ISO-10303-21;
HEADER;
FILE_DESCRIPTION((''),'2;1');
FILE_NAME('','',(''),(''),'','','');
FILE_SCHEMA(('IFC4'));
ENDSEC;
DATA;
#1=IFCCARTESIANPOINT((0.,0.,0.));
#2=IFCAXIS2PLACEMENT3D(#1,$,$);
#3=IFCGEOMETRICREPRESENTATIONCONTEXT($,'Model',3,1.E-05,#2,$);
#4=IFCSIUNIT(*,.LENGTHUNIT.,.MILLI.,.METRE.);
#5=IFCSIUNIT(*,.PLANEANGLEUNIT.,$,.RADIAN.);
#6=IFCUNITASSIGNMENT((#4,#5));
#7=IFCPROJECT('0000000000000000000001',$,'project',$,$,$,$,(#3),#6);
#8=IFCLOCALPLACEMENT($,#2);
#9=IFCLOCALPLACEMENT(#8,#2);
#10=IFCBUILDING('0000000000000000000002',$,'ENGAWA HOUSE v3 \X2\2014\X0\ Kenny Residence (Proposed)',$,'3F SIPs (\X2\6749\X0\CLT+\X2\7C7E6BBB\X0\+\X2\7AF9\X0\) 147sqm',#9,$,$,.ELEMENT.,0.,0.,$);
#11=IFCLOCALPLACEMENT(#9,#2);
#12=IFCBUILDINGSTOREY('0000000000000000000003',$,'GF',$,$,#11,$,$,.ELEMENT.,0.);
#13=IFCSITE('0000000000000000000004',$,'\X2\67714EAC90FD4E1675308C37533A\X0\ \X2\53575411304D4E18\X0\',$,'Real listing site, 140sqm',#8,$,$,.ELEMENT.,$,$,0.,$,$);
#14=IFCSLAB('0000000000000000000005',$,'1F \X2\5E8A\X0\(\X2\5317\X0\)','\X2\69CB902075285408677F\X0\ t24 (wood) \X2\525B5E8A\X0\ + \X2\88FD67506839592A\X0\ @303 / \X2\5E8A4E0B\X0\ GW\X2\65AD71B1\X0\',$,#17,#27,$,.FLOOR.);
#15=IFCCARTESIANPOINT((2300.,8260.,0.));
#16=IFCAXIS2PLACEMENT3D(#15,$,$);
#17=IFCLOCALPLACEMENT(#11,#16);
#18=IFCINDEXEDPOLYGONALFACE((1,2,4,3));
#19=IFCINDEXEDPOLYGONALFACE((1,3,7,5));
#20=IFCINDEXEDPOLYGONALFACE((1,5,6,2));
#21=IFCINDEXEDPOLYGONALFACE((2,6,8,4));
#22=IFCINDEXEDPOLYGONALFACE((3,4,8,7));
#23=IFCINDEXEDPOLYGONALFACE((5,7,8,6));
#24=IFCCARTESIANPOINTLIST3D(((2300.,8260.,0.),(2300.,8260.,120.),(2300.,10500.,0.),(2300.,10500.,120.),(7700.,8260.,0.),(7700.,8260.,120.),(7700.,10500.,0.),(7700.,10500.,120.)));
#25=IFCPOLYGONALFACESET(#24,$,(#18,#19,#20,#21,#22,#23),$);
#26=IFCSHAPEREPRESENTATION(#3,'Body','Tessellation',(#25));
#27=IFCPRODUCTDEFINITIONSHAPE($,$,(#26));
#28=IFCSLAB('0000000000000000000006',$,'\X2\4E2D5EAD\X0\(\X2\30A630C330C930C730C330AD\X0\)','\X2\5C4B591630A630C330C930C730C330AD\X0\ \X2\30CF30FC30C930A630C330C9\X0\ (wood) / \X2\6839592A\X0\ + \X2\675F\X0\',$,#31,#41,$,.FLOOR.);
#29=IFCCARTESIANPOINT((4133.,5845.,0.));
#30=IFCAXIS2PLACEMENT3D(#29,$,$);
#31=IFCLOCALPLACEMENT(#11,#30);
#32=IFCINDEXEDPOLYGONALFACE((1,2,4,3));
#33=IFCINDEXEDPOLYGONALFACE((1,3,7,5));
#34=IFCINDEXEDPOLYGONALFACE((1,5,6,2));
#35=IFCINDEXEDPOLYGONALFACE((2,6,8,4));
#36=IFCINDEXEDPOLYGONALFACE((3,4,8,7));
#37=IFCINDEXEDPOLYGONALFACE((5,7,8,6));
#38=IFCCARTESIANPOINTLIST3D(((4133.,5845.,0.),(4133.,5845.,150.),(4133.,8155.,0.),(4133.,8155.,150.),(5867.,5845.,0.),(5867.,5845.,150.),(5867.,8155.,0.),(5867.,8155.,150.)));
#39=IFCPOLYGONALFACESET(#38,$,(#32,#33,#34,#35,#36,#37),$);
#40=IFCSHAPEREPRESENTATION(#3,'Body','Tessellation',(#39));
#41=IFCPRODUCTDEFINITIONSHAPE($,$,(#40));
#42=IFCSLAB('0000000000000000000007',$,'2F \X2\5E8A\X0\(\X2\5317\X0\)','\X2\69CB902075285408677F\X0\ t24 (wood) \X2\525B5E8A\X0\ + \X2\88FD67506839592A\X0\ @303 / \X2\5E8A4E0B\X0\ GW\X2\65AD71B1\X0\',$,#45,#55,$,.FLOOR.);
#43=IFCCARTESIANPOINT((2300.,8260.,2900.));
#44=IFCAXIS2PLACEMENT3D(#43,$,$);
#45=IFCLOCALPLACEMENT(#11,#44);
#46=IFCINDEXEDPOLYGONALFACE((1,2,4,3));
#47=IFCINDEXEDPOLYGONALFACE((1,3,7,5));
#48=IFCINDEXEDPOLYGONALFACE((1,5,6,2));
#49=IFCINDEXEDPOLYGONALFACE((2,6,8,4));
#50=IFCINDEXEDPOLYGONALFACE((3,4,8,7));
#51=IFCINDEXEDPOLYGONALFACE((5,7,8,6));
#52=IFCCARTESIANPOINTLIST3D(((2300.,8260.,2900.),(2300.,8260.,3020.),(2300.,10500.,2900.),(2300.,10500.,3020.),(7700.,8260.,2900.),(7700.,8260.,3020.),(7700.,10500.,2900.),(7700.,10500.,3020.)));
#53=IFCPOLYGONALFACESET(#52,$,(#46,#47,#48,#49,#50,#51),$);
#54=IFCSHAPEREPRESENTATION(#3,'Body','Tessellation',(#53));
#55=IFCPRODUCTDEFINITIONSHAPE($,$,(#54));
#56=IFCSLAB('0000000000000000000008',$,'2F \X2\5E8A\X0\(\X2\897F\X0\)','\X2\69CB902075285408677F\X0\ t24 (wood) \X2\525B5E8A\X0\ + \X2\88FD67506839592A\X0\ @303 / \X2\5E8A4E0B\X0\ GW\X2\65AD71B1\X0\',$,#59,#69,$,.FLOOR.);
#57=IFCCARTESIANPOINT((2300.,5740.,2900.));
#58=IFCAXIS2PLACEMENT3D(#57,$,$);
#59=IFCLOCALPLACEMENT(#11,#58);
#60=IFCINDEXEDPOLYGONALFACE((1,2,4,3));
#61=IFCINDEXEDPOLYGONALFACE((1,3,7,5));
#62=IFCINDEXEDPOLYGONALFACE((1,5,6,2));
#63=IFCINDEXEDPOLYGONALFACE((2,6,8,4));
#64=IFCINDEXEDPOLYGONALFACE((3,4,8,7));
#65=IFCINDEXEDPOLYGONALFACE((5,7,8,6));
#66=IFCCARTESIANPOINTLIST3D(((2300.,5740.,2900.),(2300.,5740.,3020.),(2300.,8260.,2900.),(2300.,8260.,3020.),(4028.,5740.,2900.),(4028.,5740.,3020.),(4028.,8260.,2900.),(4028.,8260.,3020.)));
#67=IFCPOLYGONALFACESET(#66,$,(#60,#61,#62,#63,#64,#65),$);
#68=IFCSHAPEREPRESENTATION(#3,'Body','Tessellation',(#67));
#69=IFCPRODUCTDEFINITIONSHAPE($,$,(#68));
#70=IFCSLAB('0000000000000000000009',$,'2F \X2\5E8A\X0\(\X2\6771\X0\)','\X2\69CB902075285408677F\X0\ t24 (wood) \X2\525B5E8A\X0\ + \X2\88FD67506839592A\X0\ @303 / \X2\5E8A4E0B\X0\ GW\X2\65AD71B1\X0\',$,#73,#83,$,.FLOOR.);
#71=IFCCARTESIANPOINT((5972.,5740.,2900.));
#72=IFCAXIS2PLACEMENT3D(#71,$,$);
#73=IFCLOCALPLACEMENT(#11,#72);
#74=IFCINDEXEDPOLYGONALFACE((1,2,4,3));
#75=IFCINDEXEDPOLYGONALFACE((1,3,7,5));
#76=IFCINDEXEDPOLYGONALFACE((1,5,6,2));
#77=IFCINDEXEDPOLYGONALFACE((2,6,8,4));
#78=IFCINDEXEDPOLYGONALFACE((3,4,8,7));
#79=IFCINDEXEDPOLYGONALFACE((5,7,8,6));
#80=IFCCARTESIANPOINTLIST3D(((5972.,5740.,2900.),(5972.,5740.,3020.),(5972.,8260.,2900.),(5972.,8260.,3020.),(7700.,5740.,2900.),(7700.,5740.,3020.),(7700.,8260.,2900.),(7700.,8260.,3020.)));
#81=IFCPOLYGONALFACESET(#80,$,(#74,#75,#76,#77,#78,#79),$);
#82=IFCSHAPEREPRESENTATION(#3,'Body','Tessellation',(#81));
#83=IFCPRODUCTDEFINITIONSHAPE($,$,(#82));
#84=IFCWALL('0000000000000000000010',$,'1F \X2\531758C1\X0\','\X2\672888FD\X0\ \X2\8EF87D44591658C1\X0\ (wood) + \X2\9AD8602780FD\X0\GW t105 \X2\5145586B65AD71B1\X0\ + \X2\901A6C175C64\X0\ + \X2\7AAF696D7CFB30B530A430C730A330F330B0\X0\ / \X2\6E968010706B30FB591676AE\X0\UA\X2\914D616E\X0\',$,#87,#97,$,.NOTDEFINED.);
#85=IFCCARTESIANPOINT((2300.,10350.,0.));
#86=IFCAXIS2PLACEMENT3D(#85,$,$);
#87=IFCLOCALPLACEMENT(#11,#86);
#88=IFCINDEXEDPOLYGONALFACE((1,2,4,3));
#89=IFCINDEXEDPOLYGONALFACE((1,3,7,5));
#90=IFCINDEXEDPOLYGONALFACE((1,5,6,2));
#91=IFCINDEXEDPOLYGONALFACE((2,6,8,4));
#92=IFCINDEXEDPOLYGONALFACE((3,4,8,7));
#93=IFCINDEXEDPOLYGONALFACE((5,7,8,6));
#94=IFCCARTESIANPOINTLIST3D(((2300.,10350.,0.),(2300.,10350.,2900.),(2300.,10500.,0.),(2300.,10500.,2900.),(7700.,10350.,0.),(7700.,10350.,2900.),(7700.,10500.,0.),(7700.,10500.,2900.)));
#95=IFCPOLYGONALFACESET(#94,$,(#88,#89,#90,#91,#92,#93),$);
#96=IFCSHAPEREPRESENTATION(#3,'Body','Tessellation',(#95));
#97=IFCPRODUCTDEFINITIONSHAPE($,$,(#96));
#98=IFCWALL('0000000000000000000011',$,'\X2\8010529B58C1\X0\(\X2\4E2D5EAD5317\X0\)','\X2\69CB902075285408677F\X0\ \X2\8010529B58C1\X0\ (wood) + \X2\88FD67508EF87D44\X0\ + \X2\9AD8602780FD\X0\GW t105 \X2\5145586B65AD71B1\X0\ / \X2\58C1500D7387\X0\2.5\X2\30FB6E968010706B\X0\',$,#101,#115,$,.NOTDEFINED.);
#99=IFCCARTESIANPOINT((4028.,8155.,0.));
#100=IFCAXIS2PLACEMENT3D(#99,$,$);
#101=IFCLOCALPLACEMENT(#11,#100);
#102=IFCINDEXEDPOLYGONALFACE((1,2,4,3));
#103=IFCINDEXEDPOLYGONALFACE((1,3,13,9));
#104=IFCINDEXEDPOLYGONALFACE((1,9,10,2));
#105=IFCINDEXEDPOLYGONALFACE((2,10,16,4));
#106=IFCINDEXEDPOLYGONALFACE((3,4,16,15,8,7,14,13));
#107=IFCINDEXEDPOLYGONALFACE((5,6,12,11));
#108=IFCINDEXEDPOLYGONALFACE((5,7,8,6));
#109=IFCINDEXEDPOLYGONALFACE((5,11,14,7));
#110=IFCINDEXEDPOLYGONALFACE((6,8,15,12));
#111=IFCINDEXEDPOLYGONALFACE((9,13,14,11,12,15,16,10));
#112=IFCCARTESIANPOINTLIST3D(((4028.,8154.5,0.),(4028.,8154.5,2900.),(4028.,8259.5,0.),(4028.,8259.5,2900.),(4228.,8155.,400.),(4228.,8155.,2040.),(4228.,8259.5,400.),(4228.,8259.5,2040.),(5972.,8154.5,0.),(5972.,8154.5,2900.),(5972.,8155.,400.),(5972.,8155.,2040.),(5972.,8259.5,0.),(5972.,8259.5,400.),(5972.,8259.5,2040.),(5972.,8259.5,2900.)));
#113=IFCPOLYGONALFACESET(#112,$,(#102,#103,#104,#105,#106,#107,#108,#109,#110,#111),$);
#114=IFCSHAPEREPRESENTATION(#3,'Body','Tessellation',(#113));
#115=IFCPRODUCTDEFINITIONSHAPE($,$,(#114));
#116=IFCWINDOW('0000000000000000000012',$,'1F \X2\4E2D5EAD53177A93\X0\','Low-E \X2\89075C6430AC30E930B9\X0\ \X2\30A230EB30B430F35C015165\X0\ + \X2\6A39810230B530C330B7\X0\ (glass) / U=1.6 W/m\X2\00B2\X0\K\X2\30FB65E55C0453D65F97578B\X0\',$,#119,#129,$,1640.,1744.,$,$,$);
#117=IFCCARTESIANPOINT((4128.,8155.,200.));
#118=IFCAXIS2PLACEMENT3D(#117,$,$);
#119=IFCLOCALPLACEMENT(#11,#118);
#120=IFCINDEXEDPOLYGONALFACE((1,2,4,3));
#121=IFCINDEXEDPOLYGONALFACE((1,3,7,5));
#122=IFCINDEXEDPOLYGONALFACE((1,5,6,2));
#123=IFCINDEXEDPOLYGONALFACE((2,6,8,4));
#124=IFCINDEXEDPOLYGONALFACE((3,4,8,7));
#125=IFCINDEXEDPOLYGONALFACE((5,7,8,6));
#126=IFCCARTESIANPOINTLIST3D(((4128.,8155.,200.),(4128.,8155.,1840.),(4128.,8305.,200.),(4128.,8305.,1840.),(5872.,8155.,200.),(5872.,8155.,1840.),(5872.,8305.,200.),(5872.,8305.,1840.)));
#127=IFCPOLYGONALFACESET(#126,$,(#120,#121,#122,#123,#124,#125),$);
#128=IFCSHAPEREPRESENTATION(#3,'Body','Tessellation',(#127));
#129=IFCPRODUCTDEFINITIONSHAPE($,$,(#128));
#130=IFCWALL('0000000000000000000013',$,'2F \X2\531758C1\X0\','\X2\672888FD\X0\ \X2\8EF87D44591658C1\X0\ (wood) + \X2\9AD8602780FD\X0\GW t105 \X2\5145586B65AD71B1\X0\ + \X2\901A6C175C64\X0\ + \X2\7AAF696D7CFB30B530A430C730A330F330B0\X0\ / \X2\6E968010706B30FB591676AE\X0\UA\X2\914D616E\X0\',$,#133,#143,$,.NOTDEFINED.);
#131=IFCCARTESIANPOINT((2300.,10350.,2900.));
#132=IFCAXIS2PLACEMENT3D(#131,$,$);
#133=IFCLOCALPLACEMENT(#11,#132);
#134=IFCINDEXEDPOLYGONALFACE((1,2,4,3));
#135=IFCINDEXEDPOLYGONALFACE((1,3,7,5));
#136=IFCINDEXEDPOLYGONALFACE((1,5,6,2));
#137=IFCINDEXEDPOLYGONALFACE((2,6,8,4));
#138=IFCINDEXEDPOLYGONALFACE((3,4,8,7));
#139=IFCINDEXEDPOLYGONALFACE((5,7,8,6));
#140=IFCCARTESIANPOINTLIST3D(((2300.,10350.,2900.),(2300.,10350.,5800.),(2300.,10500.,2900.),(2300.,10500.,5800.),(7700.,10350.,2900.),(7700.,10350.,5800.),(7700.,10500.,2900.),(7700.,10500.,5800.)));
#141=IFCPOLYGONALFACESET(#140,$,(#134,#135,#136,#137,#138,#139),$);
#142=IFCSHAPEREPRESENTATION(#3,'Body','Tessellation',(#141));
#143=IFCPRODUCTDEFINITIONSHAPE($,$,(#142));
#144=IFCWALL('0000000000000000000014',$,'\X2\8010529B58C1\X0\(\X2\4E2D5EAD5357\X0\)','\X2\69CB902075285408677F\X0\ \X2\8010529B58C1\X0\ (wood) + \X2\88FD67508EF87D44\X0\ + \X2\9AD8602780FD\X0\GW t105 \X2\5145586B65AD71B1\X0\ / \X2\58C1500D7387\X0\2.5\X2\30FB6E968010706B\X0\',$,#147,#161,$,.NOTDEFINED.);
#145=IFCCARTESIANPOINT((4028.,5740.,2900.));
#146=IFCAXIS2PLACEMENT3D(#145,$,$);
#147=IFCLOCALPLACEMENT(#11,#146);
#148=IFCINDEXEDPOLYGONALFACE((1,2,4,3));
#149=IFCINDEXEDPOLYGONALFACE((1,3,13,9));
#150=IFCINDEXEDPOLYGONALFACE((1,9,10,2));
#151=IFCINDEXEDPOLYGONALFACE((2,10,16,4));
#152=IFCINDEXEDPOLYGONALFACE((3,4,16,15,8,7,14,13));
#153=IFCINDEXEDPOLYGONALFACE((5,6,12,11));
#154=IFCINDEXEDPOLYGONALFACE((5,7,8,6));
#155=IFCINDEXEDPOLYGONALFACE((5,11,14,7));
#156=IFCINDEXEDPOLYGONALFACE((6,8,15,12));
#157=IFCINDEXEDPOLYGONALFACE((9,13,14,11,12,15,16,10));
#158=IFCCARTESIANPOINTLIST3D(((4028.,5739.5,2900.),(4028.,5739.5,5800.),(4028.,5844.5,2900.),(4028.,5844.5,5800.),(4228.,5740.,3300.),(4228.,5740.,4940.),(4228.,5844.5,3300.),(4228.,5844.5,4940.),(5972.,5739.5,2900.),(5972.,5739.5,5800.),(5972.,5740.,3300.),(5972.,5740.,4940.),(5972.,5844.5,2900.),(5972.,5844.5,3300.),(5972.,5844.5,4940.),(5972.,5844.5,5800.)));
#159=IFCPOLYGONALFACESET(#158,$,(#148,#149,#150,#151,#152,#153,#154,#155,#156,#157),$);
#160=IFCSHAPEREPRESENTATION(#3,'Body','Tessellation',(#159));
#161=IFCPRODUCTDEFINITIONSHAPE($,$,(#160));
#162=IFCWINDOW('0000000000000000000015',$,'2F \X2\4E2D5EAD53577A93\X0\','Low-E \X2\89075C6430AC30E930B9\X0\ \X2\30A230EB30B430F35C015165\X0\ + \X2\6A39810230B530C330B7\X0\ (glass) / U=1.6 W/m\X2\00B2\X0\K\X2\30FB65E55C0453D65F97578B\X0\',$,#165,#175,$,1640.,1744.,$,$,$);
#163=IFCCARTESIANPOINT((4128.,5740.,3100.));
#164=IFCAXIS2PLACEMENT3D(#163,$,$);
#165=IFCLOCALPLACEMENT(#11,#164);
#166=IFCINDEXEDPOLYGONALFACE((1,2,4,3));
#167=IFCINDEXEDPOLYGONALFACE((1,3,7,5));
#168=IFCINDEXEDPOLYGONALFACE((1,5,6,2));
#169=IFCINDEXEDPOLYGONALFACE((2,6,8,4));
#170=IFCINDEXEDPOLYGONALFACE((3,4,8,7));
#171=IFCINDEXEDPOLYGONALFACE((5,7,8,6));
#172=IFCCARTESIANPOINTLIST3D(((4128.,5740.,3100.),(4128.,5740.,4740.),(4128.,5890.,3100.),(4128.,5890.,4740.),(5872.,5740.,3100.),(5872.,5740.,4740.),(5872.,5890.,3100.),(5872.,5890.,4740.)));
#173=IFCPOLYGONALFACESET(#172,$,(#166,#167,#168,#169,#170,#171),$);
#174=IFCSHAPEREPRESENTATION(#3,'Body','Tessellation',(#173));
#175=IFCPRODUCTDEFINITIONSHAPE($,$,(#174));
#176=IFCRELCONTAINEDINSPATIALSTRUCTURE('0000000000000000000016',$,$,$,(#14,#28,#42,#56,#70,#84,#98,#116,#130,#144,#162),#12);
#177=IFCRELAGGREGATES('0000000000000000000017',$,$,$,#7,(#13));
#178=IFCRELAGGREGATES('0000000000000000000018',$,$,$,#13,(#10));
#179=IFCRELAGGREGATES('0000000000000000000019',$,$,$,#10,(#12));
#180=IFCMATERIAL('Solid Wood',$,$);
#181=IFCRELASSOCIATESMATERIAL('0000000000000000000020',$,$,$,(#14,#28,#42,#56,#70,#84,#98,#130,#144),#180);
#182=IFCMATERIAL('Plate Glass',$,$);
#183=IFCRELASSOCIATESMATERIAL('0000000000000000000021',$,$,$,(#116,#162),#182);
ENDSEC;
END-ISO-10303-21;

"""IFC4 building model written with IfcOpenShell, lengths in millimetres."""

from ifc_helpers import new_model, si_unit, frame, frame_2d, origin, place, context, project, spatial, rectangle, extrude, material, element, fill, save


model = new_model("IFC4")

# Units and contexts
model_context = context("Model", 3, precision=1e-05, world=origin())
ifc_project = project(units=[si_unit("LENGTHUNIT", "METRE", prefix="MILLI"), si_unit("PLANEANGLEUNIT", "RADIAN")], contexts=[model_context])

# Site, building, storey
site_placement = place(None, origin())
site = spatial("IfcSite", under=ifc_project, at=site_placement, Name="東京都世田谷区 南向き丘", ObjectType="Real listing site, 140sqm", CompositionType="ELEMENT", RefElevation=0.0)
building_placement = place(site_placement, origin())
building = spatial("IfcBuilding", under=site, at=building_placement, Name="ENGAWA HOUSE v3 — Kenny Residence (Proposed)", ObjectType="3F SIPs (杉CLT+籾殻+竹) 147sqm", CompositionType="ELEMENT", ElevationOfRefHeight=0.0, ElevationOfTerrain=0.0)
storey_placement = place(building_placement, origin())
storey = spatial("IfcBuildingStorey", under=building, at=storey_placement, Name="GF", CompositionType="ELEMENT", Elevation=0.0)

# Slabs
ifc_material_1 = material(Name="Solid Wood")
slab_1_placement = place(storey_placement, frame((2300.0, 8260.0, 0.0)))
element("IfcSlab", 1, at=slab_1_placement, inside=storey, material=ifc_material_1, Name="1F 床(北)", Description="構造用合板 t24 (wood) 剛床 + 製材根太 @303 / 床下 GW断熱", PredefinedType="FLOOR", context=model_context, shape_type="SweptSolid", body=[
    extrude(rectangle(XDim=5400.0, YDim=2240.0, at=frame_2d((2700.0, 1120.0))), frame((2300.0, 8260.0, 0.0)), (0.0, 0.0, 1.0), 120.0),
])
slab_2_placement = place(storey_placement, frame((4133.0, 5845.0, 0.0)))
element("IfcSlab", 2, at=slab_2_placement, inside=storey, material=ifc_material_1, Name="中庭(ウッドデッキ)", Description="屋外ウッドデッキ ハードウッド (wood) / 根太 + 束", PredefinedType="FLOOR", context=model_context, shape_type="SweptSolid", body=[
    extrude(rectangle(XDim=1734.0, YDim=2310.0, at=frame_2d((867.0, 1155.0))), frame((4133.0, 5845.0, 0.0)), (0.0, 0.0, 1.0), 150.0),
])
slab_3_placement = place(storey_placement, frame((2300.0, 8260.0, 2900.0)))
element("IfcSlab", 3, at=slab_3_placement, inside=storey, material=ifc_material_1, Name="2F 床(北)", Description="構造用合板 t24 (wood) 剛床 + 製材根太 @303 / 床下 GW断熱", PredefinedType="FLOOR", context=model_context, shape_type="SweptSolid", body=[
    extrude(rectangle(XDim=5400.0, YDim=2240.0, at=frame_2d((2700.0, 1120.0))), frame((2300.0, 8260.0, 2900.0)), (0.0, 0.0, 1.0), 120.0),
])
slab_4_placement = place(storey_placement, frame((2300.0, 5740.0, 2900.0)))
element("IfcSlab", 4, at=slab_4_placement, inside=storey, material=ifc_material_1, Name="2F 床(西)", Description="構造用合板 t24 (wood) 剛床 + 製材根太 @303 / 床下 GW断熱", PredefinedType="FLOOR", context=model_context, shape_type="SweptSolid", body=[
    extrude(rectangle(XDim=1728.0, YDim=2520.0, at=frame_2d((864.0, 1260.0))), frame((2300.0, 5740.0, 2900.0)), (0.0, 0.0, 1.0), 120.0),
])
slab_5_placement = place(storey_placement, frame((5972.0, 5740.0, 2900.0)))
element("IfcSlab", 5, at=slab_5_placement, inside=storey, material=ifc_material_1, Name="2F 床(東)", Description="構造用合板 t24 (wood) 剛床 + 製材根太 @303 / 床下 GW断熱", PredefinedType="FLOOR", context=model_context, shape_type="SweptSolid", body=[
    extrude(rectangle(XDim=1728.0, YDim=2520.0, at=frame_2d((864.0, 1260.0))), frame((5972.0, 5740.0, 2900.0)), (0.0, 0.0, 1.0), 120.0),
])

# Wall
wall_1_placement = place(storey_placement, frame((2300.0, 10350.0, 0.0)))
element("IfcWall", 6, at=wall_1_placement, inside=storey, material=ifc_material_1, Name="1F 北壁", Description="木製 軸組外壁 (wood) + 高性能GW t105 充填断熱 + 通気層 + 窯業系サイディング / 準耐火・外皮UA配慮", PredefinedType="NOTDEFINED", context=model_context, shape_type="SweptSolid", body=[
    extrude(rectangle(XDim=5400.0, YDim=150.0, at=frame_2d((2700.0, 75.0))), frame((2300.0, 10350.0, 0.0)), (0.0, 0.0, 1.0), 2900.0),
])

# Wall, opening, window
wall_2_placement = place(storey_placement, frame((4028.0, 8155.0, 0.0)))
wall_2 = element("IfcWall", 7, at=wall_2_placement, inside=storey, material=ifc_material_1, Name="耐力壁(中庭北)", Description="構造用合板 耐力壁 (wood) + 製材軸組 + 高性能GW t105 充填断熱 / 壁倍率2.5・準耐火", PredefinedType="NOTDEFINED", context=model_context, shape_type="SweptSolid", body=[
    extrude(rectangle(XDim=1944.0, YDim=105.0, at=frame_2d((972.0, 52.0))), frame((4028.0, 8155.0, 0.0)), (0.0, 0.0, 1.0), 2900.0),
])
opening_1_placement = place(storey_placement, frame((4128.0, 8155.0, 200.0)))
opening_1 = element("IfcOpeningElement", 8, at=opening_1_placement, cuts=wall_2, PredefinedType="NOTDEFINED", context=model_context, shape_type="SweptSolid", body=[
    extrude(rectangle(XDim=1744.0, YDim=150.0, at=frame_2d((872.0, 75.0))), frame((4128.0, 8155.0, 200.0)), (0.0, 0.0, 1.0), 1640.0),
])
ifc_material_2 = material(Name="Plate Glass")
window_1_placement = place(storey_placement, frame((4128.0, 8155.0, 200.0)))
window_1 = element("IfcWindow", 9, at=window_1_placement, inside=storey, material=ifc_material_2, Name="1F 中庭北窓", Description="Low-E 複層ガラス アルゴン封入 + 樹脂サッシ (glass) / U=1.6 W/m²K・日射取得型", OverallHeight=1640.0, OverallWidth=1744.0, context=model_context, shape_type="SweptSolid", body=[
    extrude(rectangle(XDim=1744.0, YDim=150.0, at=frame_2d((872.0, 75.0))), frame((4128.0, 8155.0, 200.0)), (0.0, 0.0, 1.0), 1640.0),
])
fill(opening_1, window_1)

# Wall
wall_3_placement = place(storey_placement, frame((2300.0, 10350.0, 2900.0)))
element("IfcWall", 10, at=wall_3_placement, inside=storey, material=ifc_material_1, Name="2F 北壁", Description="木製 軸組外壁 (wood) + 高性能GW t105 充填断熱 + 通気層 + 窯業系サイディング / 準耐火・外皮UA配慮", PredefinedType="NOTDEFINED", context=model_context, shape_type="SweptSolid", body=[
    extrude(rectangle(XDim=5400.0, YDim=150.0, at=frame_2d((2700.0, 75.0))), frame((2300.0, 10350.0, 2900.0)), (0.0, 0.0, 1.0), 2900.0),
])

# Wall, opening, window
wall_4_placement = place(storey_placement, frame((4028.0, 5740.0, 2900.0)))
wall_4 = element("IfcWall", 11, at=wall_4_placement, inside=storey, material=ifc_material_1, Name="耐力壁(中庭南)", Description="構造用合板 耐力壁 (wood) + 製材軸組 + 高性能GW t105 充填断熱 / 壁倍率2.5・準耐火", PredefinedType="NOTDEFINED", context=model_context, shape_type="SweptSolid", body=[
    extrude(rectangle(XDim=1944.0, YDim=105.0, at=frame_2d((972.0, 52.0))), frame((4028.0, 5740.0, 2900.0)), (0.0, 0.0, 1.0), 2900.0),
])
opening_2_placement = place(storey_placement, frame((4128.0, 5740.0, 3100.0)))
opening_2 = element("IfcOpeningElement", 12, at=opening_2_placement, cuts=wall_4, PredefinedType="NOTDEFINED", context=model_context, shape_type="SweptSolid", body=[
    extrude(rectangle(XDim=1744.0, YDim=150.0, at=frame_2d((872.0, 75.0))), frame((4128.0, 5740.0, 3100.0)), (0.0, 0.0, 1.0), 1640.0),
])
window_2_placement = place(storey_placement, frame((4128.0, 5740.0, 3100.0)))
window_2 = element("IfcWindow", 13, at=window_2_placement, inside=storey, material=ifc_material_2, Name="2F 中庭南窓", Description="Low-E 複層ガラス アルゴン封入 + 樹脂サッシ (glass) / U=1.6 W/m²K・日射取得型", OverallHeight=1640.0, OverallWidth=1744.0, context=model_context, shape_type="SweptSolid", body=[
    extrude(rectangle(XDim=1744.0, YDim=150.0, at=frame_2d((872.0, 75.0))), frame((4128.0, 5740.0, 3100.0)), (0.0, 0.0, 1.0), 1640.0),
])
fill(opening_2, window_2)

save(model, "model.ifc")
